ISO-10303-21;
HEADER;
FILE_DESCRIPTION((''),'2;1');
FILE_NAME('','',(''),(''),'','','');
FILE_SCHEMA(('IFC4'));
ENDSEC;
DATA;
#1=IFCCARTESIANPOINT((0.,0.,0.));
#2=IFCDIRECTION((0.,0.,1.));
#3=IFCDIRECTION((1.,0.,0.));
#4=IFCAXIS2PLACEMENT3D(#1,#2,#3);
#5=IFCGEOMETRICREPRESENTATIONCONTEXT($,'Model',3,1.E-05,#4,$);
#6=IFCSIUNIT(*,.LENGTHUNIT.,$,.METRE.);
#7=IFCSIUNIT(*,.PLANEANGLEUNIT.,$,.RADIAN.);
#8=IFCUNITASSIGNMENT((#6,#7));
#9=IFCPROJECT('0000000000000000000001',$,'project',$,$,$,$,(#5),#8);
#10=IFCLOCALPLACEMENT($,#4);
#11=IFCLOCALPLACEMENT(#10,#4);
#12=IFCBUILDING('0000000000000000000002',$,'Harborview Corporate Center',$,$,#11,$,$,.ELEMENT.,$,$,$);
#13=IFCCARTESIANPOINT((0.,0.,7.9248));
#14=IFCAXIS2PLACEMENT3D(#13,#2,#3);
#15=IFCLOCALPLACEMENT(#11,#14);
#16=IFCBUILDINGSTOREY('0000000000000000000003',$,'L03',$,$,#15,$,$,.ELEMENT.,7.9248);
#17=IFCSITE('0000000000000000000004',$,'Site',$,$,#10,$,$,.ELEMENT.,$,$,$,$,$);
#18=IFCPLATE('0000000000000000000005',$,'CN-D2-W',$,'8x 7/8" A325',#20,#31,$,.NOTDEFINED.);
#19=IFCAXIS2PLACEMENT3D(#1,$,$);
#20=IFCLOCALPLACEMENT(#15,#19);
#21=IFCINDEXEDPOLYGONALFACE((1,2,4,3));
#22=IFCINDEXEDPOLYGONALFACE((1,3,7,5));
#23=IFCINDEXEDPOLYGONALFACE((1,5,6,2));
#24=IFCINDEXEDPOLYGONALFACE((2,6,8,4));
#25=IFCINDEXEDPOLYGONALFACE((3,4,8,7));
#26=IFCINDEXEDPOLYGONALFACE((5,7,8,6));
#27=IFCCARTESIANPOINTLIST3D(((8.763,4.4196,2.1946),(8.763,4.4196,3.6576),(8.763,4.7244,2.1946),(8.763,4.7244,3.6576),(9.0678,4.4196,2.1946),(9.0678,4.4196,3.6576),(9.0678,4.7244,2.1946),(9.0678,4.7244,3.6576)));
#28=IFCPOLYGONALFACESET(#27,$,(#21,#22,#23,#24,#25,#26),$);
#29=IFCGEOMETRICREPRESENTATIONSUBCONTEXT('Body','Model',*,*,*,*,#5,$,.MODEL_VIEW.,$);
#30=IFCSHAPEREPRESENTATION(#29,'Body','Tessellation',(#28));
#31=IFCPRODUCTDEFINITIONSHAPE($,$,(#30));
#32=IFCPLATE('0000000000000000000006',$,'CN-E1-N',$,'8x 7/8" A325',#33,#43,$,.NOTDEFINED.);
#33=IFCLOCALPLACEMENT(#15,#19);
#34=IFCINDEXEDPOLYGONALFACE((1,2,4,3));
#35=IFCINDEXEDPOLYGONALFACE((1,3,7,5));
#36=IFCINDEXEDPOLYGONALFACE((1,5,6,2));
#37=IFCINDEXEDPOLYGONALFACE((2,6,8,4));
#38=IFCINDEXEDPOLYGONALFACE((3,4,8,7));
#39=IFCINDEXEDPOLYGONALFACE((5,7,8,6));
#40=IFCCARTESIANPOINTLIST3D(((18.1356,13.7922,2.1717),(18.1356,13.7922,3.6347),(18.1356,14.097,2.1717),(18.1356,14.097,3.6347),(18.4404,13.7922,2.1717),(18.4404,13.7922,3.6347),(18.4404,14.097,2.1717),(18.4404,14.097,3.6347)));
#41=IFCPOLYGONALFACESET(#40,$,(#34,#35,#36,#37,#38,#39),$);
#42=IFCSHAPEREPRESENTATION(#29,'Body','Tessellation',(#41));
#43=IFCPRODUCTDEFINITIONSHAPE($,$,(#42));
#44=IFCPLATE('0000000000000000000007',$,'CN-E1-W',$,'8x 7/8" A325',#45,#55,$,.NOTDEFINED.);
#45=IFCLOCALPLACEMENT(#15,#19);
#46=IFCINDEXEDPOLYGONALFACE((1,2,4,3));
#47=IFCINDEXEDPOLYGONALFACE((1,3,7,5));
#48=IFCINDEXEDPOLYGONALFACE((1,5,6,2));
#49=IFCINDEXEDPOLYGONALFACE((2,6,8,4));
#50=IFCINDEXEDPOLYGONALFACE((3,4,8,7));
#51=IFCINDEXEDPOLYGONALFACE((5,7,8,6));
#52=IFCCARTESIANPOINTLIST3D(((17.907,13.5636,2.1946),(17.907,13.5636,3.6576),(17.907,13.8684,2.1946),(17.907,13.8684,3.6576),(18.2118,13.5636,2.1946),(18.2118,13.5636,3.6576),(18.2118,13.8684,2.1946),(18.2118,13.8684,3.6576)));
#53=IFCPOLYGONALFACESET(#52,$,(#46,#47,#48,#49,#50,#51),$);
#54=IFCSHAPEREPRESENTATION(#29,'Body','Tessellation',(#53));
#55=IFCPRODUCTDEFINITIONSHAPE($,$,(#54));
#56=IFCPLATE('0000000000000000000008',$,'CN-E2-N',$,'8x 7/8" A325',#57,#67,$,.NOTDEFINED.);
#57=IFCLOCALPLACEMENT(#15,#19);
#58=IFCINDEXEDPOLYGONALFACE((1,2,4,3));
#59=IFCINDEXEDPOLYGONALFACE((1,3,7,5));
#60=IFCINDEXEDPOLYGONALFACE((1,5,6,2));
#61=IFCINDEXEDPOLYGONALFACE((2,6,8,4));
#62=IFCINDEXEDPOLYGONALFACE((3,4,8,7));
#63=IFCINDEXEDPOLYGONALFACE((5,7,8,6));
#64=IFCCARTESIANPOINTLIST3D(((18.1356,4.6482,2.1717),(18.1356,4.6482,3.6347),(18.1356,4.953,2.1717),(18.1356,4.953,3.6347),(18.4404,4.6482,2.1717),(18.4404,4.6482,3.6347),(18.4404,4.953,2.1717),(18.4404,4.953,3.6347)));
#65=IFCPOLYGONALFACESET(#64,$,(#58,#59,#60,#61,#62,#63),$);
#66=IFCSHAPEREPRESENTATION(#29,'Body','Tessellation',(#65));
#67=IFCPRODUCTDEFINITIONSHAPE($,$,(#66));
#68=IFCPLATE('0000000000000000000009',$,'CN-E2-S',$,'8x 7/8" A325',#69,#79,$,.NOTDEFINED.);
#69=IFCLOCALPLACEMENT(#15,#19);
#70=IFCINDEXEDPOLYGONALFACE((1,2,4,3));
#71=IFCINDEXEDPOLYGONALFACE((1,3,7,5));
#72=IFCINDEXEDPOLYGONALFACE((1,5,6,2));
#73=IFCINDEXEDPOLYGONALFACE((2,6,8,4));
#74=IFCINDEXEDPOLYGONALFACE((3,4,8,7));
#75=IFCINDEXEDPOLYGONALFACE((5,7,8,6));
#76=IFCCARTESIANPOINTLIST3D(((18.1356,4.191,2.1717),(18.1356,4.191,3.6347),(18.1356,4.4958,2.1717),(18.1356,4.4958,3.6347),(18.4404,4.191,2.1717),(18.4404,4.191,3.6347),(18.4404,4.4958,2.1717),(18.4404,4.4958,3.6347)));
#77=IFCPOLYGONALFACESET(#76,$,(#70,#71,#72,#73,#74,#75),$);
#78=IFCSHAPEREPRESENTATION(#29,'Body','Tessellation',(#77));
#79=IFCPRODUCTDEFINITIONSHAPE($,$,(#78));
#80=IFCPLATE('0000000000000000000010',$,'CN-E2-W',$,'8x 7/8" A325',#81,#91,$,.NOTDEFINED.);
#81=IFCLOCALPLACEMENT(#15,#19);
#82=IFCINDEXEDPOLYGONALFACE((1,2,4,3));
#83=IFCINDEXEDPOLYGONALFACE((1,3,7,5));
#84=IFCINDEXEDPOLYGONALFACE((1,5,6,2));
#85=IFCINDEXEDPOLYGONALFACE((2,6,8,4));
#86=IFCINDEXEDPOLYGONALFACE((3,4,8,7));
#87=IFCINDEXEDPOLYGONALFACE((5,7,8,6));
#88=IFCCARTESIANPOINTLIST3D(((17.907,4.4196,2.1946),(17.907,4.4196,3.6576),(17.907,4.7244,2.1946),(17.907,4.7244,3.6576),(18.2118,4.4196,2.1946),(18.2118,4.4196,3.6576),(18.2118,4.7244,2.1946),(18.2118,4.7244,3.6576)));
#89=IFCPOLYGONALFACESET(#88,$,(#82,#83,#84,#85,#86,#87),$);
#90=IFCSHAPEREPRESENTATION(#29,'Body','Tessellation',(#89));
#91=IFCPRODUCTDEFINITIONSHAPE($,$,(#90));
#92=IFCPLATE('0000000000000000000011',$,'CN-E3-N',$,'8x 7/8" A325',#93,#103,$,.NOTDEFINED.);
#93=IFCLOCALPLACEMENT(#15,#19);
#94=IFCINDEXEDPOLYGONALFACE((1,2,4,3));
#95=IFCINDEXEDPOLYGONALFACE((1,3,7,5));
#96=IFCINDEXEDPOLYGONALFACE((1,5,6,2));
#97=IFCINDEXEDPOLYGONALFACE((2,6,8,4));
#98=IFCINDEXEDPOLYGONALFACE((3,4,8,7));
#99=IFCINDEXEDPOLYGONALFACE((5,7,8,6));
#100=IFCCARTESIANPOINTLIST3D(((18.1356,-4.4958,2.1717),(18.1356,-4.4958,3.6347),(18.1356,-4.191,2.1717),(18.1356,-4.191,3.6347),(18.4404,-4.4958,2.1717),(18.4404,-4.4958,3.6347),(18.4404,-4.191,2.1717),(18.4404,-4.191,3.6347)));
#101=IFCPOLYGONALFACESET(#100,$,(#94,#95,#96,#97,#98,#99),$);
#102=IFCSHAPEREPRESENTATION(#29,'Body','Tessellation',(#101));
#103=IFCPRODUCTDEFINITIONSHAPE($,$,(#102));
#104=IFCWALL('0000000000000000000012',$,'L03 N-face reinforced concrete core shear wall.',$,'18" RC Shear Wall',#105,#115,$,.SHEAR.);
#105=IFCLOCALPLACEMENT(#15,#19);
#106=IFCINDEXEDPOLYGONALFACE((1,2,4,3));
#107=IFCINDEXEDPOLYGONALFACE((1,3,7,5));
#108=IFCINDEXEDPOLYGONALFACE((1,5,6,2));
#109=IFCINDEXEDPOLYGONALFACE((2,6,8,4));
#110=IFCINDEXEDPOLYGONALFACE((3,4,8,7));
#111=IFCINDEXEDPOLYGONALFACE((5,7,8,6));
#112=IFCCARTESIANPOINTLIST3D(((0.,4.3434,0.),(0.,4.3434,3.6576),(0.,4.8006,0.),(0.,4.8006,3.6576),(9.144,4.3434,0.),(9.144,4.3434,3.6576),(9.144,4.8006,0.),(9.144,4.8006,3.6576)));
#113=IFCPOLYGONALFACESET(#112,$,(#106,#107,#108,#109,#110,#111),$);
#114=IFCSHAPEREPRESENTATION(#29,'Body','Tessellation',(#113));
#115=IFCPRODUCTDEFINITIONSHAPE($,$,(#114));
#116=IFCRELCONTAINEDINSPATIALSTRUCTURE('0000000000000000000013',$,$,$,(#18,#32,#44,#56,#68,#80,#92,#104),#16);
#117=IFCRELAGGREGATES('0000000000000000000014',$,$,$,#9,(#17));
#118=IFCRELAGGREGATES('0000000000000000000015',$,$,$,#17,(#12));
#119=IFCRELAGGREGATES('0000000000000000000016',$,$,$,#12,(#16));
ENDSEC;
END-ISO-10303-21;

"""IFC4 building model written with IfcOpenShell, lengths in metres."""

from ifc_helpers import new_model, si_unit, frame, origin_with_axes, place, context, subcontext, project, spatial, rectangle, extrude, element, save


model = new_model("IFC4")

# Units and contexts
model_context = context("Model", 3, precision=1e-05, world=origin_with_axes())
body_context = subcontext(model_context, "Body", "Model", "MODEL_VIEW")
ifc_project = project(units=[si_unit("LENGTHUNIT", "METRE"), si_unit("PLANEANGLEUNIT", "RADIAN")], contexts=[model_context])

# Site, building, storey
site_placement = place(None, origin_with_axes())
site = spatial("IfcSite", under=ifc_project, at=site_placement, Name="Site", CompositionType="ELEMENT")
building_placement = place(site_placement, origin_with_axes())
building = spatial("IfcBuilding", under=site, at=building_placement, Name="Harborview Corporate Center", CompositionType="ELEMENT")
storey_placement = place(building_placement, frame((0.0, 0.0, 7.9248), z_axis=(0.0, 0.0, 1.0), x_axis=(1.0, 0.0, 0.0)))
storey = spatial("IfcBuildingStorey", under=building, at=storey_placement, Name="L03", CompositionType="ELEMENT", Elevation=7.9248)

# Plates
for number, where, z_axis, x_axis, name in (
    (1, (8.9154, 4.572, 2.1946), (0.0, 0.0, 1.0), (1.0, 0.0, 0.0), "CN-D2-W"),
    (2, (18.288, 13.9446, 2.1717), (0.0, 0.0, 1.0), (1.0, 0.0, 0.0), "CN-E1-N"),
    (3, (18.0594, 13.716, 2.1946), (0.0, 0.0, 1.0), (1.0, 0.0, 0.0), "CN-E1-W"),
    (4, (18.288, 4.8006, 2.1717), (0.0, 0.0, 1.0), (1.0, 0.0, 0.0), "CN-E2-N"),
    (5, (18.288, 4.3434, 2.1717), (0.0, 0.0, 1.0), (1.0, 0.0, 0.0), "CN-E2-S"),
    (6, (18.0594, 4.572, 2.1946), (0.0, 0.0, 1.0), (1.0, 0.0, 0.0), "CN-E2-W"),
    (7, (18.288, -4.3434, 2.1717), (0.0, 0.0, 1.0), (1.0, 0.0, 0.0), "CN-E3-N"),
):
    element("IfcPlate", number, at=place(storey_placement, frame(where, z_axis=z_axis, x_axis=x_axis)), inside=storey, Name=name, ObjectType="8x 7/8\" A325", PredefinedType="NOTDEFINED", context=body_context, shape_type="SweptSolid", body=[
        extrude(rectangle(XDim=0.3048, YDim=0.3048), origin_with_axes(), (0.0, 0.0, 1.0), 1.463),
    ])

# Wall
wall_placement = place(storey_placement, frame((4.572, 4.572, 0.0), z_axis=(0.0, 0.0, 1.0), x_axis=(1.0, 0.0, 0.0)))
element("IfcWall", 8, at=wall_placement, inside=storey, Name="L03 N-face reinforced concrete core shear wall.", ObjectType="18\" RC Shear Wall", PredefinedType="SHEAR", context=body_context, shape_type="SweptSolid", body=[
    extrude(rectangle(XDim=9.144, YDim=0.4572), origin_with_axes(), (0.0, 0.0, 1.0), 3.6576),
])

save(model, "model.ifc")
